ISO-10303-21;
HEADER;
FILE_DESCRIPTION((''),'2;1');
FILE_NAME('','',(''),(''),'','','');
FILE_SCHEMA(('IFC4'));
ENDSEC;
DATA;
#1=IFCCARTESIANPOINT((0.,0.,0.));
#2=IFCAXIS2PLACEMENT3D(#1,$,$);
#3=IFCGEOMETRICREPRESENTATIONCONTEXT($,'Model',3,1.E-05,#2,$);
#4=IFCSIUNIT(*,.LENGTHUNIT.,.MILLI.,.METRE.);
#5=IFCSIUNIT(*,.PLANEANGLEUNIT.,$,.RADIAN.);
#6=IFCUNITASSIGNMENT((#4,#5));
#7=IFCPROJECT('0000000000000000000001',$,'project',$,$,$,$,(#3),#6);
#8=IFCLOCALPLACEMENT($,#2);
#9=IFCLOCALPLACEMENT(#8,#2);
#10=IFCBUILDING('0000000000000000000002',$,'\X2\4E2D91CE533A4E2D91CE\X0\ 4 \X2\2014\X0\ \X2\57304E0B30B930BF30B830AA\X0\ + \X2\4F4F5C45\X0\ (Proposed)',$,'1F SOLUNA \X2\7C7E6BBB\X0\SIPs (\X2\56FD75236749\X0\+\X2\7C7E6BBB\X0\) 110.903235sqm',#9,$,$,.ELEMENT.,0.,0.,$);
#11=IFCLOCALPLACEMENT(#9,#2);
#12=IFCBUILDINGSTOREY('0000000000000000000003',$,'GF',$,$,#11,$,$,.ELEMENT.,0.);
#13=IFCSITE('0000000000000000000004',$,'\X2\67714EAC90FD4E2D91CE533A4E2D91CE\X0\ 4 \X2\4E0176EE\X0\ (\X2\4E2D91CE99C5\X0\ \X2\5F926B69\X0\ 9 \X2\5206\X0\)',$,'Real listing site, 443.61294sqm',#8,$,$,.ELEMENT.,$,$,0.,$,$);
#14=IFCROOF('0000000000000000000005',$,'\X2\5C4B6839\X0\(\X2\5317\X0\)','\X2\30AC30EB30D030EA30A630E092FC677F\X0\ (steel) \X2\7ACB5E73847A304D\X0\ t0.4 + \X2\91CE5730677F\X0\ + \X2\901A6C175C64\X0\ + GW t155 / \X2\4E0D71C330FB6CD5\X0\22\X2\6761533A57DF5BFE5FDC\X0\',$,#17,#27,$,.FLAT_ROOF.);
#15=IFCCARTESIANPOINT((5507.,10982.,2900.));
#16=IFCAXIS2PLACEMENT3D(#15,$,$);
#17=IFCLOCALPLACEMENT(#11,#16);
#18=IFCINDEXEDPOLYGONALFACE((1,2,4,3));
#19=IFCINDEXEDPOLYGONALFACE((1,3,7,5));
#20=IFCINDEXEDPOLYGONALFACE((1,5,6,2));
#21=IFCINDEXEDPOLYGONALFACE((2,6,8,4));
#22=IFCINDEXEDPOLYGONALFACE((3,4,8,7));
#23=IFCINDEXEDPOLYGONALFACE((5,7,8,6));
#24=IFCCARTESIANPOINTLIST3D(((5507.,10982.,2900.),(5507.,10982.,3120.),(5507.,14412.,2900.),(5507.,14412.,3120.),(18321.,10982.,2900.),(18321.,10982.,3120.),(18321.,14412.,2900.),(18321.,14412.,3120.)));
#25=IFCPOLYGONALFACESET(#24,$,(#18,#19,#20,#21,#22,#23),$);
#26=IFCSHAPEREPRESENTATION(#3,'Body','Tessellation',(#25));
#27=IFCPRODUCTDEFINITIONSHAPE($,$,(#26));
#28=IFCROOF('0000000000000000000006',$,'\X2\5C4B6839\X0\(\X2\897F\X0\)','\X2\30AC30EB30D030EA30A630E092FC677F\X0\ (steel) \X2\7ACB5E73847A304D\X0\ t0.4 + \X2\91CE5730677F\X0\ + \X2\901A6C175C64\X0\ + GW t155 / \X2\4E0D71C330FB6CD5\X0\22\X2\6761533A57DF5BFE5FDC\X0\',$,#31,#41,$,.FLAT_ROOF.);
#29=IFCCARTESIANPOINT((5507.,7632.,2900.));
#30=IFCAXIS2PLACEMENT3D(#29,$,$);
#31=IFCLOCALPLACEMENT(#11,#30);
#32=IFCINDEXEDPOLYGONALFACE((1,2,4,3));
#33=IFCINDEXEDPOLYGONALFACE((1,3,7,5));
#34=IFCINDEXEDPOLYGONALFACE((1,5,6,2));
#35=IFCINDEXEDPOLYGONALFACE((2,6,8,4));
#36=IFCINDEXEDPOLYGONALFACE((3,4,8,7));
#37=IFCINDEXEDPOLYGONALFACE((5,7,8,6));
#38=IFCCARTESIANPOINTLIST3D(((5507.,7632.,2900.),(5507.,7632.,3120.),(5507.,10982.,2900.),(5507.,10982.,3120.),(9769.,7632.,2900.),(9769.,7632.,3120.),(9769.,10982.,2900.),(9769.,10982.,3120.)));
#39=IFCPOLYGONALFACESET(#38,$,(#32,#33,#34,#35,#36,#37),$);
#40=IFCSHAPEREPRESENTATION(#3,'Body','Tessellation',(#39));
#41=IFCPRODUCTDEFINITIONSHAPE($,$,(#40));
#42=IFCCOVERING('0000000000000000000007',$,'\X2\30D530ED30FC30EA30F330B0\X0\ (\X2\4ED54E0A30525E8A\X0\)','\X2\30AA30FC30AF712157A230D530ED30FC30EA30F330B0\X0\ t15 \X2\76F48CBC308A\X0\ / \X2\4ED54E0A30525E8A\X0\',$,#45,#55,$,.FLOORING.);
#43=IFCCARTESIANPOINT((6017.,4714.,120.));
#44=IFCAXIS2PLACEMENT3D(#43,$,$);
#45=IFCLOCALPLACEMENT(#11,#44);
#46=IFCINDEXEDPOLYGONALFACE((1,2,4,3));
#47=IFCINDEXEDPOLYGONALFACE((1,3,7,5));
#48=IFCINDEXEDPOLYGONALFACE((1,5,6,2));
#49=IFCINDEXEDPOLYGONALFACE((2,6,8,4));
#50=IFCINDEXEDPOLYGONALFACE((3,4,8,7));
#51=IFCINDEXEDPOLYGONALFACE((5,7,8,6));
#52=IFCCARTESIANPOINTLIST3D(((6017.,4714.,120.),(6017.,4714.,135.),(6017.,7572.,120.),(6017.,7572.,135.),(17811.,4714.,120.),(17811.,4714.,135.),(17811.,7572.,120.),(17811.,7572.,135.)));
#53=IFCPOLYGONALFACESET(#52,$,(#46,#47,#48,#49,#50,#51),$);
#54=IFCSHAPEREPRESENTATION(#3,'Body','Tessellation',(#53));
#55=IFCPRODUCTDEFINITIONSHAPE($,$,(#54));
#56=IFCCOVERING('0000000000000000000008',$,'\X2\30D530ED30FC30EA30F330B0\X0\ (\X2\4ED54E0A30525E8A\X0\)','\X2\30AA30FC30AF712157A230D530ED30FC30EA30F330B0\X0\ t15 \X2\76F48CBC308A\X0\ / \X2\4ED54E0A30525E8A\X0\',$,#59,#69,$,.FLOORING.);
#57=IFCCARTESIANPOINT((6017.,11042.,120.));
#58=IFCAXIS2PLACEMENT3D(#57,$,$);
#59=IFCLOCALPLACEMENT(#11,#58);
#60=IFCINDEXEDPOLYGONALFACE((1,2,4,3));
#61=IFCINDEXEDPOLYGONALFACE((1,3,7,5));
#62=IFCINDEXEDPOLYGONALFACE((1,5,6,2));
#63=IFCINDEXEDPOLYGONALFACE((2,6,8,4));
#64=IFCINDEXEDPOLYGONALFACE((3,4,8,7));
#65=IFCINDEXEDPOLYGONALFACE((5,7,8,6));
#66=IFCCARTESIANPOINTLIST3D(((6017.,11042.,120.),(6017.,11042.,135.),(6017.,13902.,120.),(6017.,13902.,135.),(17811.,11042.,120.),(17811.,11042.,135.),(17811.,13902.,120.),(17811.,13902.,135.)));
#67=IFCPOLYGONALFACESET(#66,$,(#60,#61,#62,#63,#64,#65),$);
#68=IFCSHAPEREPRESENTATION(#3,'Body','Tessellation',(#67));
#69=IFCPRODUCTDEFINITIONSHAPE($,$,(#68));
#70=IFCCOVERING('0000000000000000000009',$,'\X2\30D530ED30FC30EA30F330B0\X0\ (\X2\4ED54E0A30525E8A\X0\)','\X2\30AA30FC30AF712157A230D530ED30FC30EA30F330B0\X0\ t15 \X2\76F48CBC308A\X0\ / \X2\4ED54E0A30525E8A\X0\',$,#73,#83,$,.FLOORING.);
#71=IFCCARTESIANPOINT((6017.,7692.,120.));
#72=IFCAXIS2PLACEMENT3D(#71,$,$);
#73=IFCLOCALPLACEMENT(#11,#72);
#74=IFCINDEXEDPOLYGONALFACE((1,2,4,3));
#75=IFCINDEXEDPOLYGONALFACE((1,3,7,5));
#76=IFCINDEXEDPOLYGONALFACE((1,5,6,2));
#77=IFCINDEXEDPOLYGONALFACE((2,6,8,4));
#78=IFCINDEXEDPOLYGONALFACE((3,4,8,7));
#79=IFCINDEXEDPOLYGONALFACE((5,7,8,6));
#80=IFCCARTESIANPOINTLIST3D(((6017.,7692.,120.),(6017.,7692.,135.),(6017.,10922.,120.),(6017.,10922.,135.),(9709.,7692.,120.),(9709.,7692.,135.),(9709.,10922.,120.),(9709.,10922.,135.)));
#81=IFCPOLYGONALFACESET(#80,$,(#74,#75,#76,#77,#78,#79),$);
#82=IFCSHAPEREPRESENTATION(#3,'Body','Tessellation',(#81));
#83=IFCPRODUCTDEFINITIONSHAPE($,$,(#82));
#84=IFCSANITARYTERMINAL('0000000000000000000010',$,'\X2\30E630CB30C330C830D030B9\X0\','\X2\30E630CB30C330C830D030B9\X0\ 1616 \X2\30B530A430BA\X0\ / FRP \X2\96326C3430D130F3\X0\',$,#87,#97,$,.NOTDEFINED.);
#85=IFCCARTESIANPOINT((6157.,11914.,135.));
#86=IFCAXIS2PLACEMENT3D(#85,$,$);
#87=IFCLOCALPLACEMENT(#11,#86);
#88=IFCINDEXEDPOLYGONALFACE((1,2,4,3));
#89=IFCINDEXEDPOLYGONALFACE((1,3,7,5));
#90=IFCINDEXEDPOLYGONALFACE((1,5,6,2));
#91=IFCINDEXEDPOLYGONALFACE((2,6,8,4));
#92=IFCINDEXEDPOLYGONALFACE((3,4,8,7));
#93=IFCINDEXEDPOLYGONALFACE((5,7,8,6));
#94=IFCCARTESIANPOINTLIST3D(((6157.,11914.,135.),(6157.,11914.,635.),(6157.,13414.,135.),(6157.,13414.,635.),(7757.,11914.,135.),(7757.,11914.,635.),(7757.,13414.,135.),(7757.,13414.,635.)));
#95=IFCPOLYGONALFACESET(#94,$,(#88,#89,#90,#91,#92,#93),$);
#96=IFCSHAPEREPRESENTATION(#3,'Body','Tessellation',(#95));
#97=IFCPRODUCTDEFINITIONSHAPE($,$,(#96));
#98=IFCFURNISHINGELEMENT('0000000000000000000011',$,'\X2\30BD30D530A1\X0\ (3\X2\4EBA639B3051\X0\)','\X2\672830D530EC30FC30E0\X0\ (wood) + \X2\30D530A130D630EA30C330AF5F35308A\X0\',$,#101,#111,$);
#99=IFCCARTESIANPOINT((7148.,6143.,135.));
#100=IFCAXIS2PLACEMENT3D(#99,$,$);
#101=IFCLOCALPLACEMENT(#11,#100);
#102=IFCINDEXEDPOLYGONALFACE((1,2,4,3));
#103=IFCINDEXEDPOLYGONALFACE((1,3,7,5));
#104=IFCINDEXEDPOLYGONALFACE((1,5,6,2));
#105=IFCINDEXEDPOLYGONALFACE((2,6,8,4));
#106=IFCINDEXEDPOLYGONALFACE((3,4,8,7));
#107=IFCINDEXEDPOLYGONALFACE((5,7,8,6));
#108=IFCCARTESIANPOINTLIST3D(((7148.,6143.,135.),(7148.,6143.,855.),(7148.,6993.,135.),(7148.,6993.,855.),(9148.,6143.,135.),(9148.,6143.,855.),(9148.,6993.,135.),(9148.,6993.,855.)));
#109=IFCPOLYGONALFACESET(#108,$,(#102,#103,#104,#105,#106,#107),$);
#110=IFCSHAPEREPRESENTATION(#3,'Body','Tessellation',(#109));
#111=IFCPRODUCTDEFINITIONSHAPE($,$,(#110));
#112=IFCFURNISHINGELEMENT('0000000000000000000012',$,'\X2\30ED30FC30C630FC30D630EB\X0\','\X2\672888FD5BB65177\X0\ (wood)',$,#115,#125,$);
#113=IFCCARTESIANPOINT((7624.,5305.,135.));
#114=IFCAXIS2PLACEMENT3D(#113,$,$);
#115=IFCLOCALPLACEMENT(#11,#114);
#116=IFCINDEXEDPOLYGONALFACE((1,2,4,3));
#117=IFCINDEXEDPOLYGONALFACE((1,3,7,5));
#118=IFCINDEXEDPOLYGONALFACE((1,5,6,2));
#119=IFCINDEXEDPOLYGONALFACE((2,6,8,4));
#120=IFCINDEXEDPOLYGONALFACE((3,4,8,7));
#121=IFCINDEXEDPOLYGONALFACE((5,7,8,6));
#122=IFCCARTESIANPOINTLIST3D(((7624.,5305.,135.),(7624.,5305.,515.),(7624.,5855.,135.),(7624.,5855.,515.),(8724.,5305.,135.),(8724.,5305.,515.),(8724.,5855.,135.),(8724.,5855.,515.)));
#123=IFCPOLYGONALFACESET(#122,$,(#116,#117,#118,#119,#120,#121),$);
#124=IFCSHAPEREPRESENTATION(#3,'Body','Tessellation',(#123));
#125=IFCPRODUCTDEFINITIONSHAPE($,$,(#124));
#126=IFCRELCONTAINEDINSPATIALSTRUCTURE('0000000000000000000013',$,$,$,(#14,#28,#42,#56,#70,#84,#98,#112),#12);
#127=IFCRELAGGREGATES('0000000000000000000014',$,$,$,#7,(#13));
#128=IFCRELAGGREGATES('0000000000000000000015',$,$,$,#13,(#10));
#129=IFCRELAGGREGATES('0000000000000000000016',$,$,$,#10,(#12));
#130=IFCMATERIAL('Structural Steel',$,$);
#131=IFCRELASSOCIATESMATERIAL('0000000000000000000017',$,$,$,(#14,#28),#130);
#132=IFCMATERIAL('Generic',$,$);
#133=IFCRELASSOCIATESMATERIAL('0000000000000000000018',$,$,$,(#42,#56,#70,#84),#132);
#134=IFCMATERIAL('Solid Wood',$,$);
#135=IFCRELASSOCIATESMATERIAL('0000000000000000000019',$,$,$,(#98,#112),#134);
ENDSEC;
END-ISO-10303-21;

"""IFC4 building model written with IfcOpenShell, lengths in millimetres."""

from ifc_helpers import new_model, si_unit, frame, frame_2d, origin, place, context, project, spatial, rectangle, extrude, material, element, save


model = new_model("IFC4")

# Units and contexts
model_context = context("Model", 3, precision=1e-05, world=origin())
ifc_project = project(units=[si_unit("LENGTHUNIT", "METRE", prefix="MILLI"), si_unit("PLANEANGLEUNIT", "RADIAN")], contexts=[model_context])

# Site, building, storey
site_placement = place(None, origin())
site = spatial("IfcSite", under=ifc_project, at=site_placement, Name="東京都中野区中野 4 丁目 (中野駅 徒歩 9 分)", ObjectType="Real listing site, 443.61294sqm", CompositionType="ELEMENT", RefElevation=0.0)
building_placement = place(site_placement, origin())
building = spatial("IfcBuilding", under=site, at=building_placement, Name="中野区中野 4 — 地下スタジオ + 住居 (Proposed)", ObjectType="1F SOLUNA 籾殻SIPs (国産杉+籾殻) 110.903235sqm", CompositionType="ELEMENT", ElevationOfRefHeight=0.0, ElevationOfTerrain=0.0)
storey_placement = place(building_placement, origin())
storey = spatial("IfcBuildingStorey", under=building, at=storey_placement, Name="GF", CompositionType="ELEMENT", Elevation=0.0)

# Shared definitions
ifc_material_1 = material(Name="Solid Wood")

# Roofs
ifc_material_2 = material(Name="Structural Steel")
roof_1_placement = place(storey_placement, frame((5507.0, 10982.0, 2900.0)))
element("IfcRoof", 1, at=roof_1_placement, inside=storey, material=ifc_material_2, Name="屋根(北)", Description="ガルバリウム鋼板 (steel) 立平葺き t0.4 + 野地板 + 通気層 + GW t155 / 不燃・法22条区域対応", PredefinedType="FLAT_ROOF", context=model_context, shape_type="SweptSolid", body=[
    extrude(rectangle(XDim=12814.0, YDim=3430.0, at=frame_2d((6407.0, 1715.0))), frame((5507.0, 10982.0, 2900.0)), (0.0, 0.0, 1.0), 220.0),
])
roof_2_placement = place(storey_placement, frame((5507.0, 7632.0, 2900.0)))
element("IfcRoof", 2, at=roof_2_placement, inside=storey, material=ifc_material_2, Name="屋根(西)", Description="ガルバリウム鋼板 (steel) 立平葺き t0.4 + 野地板 + 通気層 + GW t155 / 不燃・法22条区域対応", PredefinedType="FLAT_ROOF", context=model_context, shape_type="SweptSolid", body=[
    extrude(rectangle(XDim=4262.0, YDim=3350.0, at=frame_2d((2131.0, 1675.0))), frame((5507.0, 7632.0, 2900.0)), (0.0, 0.0, 1.0), 220.0),
])

# Coverings
ifc_material_3 = material(Name="Generic")
covering_1_placement = place(storey_placement, frame((6017.0, 4714.0, 120.0)))
element("IfcCovering", 3, at=covering_1_placement, inside=storey, material=ifc_material_3, Name="フローリング (仕上げ床)", Description="オーク無垢フローリング t15 直貼り / 仕上げ床", PredefinedType="FLOORING", context=model_context, shape_type="SweptSolid", body=[
    extrude(rectangle(XDim=11794.0, YDim=2858.0, at=frame_2d((5897.0, 1429.0))), frame((6017.0, 4714.0, 120.0)), (0.0, 0.0, 1.0), 15.0),
])
covering_2_placement = place(storey_placement, frame((6017.0, 11042.0, 120.0)))
element("IfcCovering", 4, at=covering_2_placement, inside=storey, material=ifc_material_3, Name="フローリング (仕上げ床)", Description="オーク無垢フローリング t15 直貼り / 仕上げ床", PredefinedType="FLOORING", context=model_context, shape_type="SweptSolid", body=[
    extrude(rectangle(XDim=11794.0, YDim=2860.0, at=frame_2d((5897.0, 1430.0))), frame((6017.0, 11042.0, 120.0)), (0.0, 0.0, 1.0), 15.0),
])
covering_3_placement = place(storey_placement, frame((6017.0, 7692.0, 120.0)))
element("IfcCovering", 5, at=covering_3_placement, inside=storey, material=ifc_material_3, Name="フローリング (仕上げ床)", Description="オーク無垢フローリング t15 直貼り / 仕上げ床", PredefinedType="FLOORING", context=model_context, shape_type="SweptSolid", body=[
    extrude(rectangle(XDim=3692.0, YDim=3230.0, at=frame_2d((1846.0, 1615.0))), frame((6017.0, 7692.0, 120.0)), (0.0, 0.0, 1.0), 15.0),
])

# Sanitary terminal
sanitary_terminal_placement = place(storey_placement, frame((6157.0, 11914.0, 135.0)))
element("IfcSanitaryTerminal", 6, at=sanitary_terminal_placement, inside=storey, material=ifc_material_3, Name="ユニットバス", Description="ユニットバス 1616 サイズ / FRP 防水パン", PredefinedType="NOTDEFINED", context=model_context, shape_type="SweptSolid", body=[
    extrude(rectangle(XDim=1600.0, YDim=1500.0, at=frame_2d((800.0, 750.0))), frame((6157.0, 11914.0, 135.0)), (0.0, 0.0, 1.0), 500.0),
])

# Furnishing elements
furnishing_1_placement = place(storey_placement, frame((7148.0, 6143.0, 135.0)))
element("IfcFurnishingElement", 7, at=furnishing_1_placement, inside=storey, material=ifc_material_1, Name="ソファ (3人掛け)", Description="木フレーム (wood) + ファブリック張り", context=model_context, shape_type="SweptSolid", body=[
    extrude(rectangle(XDim=2000.0, YDim=850.0, at=frame_2d((1000.0, 425.0))), frame((7148.0, 6143.0, 135.0)), (0.0, 0.0, 1.0), 720.0),
])
furnishing_2_placement = place(storey_placement, frame((7624.0, 5305.0, 135.0)))
element("IfcFurnishingElement", 8, at=furnishing_2_placement, inside=storey, material=ifc_material_1, Name="ローテーブル", Description="木製家具 (wood)", context=model_context, shape_type="SweptSolid", body=[
    extrude(rectangle(XDim=1100.0, YDim=550.0, at=frame_2d((550.0, 275.0))), frame((7624.0, 5305.0, 135.0)), (0.0, 0.0, 1.0), 380.0),
])

save(model, "model.ifc")
